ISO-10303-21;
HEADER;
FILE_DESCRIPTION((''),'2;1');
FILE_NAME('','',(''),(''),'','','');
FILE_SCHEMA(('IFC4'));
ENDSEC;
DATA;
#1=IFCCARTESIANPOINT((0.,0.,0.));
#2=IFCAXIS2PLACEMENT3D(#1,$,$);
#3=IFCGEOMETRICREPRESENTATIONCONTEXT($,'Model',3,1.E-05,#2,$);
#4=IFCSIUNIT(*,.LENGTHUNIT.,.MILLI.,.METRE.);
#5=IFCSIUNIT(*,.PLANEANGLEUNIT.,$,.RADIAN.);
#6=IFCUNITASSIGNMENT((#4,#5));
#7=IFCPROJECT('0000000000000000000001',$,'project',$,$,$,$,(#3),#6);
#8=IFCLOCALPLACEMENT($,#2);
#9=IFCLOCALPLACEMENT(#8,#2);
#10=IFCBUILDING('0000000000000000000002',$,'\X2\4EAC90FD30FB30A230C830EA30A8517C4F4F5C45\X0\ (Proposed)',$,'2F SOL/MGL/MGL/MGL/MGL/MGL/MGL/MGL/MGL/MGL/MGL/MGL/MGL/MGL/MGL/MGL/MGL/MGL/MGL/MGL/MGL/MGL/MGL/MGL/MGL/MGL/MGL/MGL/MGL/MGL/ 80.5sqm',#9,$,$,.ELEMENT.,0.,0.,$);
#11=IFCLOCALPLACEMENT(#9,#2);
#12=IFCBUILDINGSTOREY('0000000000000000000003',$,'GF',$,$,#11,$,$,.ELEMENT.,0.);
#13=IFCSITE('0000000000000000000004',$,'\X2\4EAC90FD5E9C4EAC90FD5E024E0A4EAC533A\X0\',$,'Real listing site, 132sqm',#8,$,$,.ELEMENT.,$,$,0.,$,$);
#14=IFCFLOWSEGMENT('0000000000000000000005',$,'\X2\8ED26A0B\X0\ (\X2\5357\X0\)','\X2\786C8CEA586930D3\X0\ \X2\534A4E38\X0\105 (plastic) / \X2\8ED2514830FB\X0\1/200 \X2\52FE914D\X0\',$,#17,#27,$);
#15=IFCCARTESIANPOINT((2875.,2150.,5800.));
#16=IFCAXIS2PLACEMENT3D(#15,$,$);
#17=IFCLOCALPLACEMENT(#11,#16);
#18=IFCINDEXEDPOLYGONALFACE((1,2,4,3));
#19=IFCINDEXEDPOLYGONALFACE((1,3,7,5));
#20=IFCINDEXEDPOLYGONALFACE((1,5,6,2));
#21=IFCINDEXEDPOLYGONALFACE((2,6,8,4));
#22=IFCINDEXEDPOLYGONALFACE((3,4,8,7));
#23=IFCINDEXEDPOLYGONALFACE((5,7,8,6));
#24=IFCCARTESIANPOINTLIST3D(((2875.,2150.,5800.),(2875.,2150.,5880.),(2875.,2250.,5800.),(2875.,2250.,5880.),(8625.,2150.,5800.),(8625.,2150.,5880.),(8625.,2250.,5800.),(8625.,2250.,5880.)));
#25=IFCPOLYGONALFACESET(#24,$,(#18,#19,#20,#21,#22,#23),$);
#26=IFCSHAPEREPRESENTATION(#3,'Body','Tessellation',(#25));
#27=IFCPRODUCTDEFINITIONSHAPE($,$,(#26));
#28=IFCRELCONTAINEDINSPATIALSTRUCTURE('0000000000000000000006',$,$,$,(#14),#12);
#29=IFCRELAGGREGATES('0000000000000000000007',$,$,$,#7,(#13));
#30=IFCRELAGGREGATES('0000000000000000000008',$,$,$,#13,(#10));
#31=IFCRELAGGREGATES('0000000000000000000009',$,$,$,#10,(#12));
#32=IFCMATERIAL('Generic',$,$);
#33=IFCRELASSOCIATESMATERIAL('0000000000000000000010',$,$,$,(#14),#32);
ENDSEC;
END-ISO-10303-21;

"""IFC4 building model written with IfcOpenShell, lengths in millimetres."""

from ifc_helpers import new_model, si_unit, frame, frame_2d, origin, place, context, project, spatial, rectangle, extrude, material, element, save


model = new_model("IFC4")

# Units and contexts
model_context = context("Model", 3, precision=1e-05, world=origin())
ifc_project = project(units=[si_unit("LENGTHUNIT", "METRE", prefix="MILLI"), si_unit("PLANEANGLEUNIT", "RADIAN")], contexts=[model_context])

# Site, building, storey
site_placement = place(None, origin())
site = spatial("IfcSite", under=ifc_project, at=site_placement, Name="京都府京都市上京区", ObjectType="Real listing site, 132sqm", CompositionType="ELEMENT", RefElevation=0.0)
building_placement = place(site_placement, origin())
building = spatial("IfcBuilding", under=site, at=building_placement, Name="京都・アトリエ兼住居 (Proposed)", ObjectType="2F SOL/MGL/MGL/MGL/MGL/MGL/MGL/MGL/MGL/MGL/MGL/MGL/MGL/MGL/MGL/MGL/MGL/MGL/MGL/MGL/MGL/MGL/MGL/MGL/MGL/MGL/MGL/MGL/MGL/MGL/ 80.5sqm", CompositionType="ELEMENT", ElevationOfRefHeight=0.0, ElevationOfTerrain=0.0)
storey_placement = place(building_placement, origin())
storey = spatial("IfcBuildingStorey", under=building, at=storey_placement, Name="GF", CompositionType="ELEMENT", Elevation=0.0)

# Flow segment
ifc_material_1 = material(Name="Generic")
flow_segment_placement = place(storey_placement, frame((2875.0, 2150.0, 5800.0)))
element("IfcFlowSegment", 1, at=flow_segment_placement, inside=storey, material=ifc_material_1, Name="軒樋 (南)", Description="硬質塩ビ 半丸105 (plastic) / 軒先・1/200 勾配", context=model_context, shape_type="SweptSolid", body=[
    extrude(rectangle(XDim=5750.0, YDim=100.0, at=frame_2d((2875.0, 50.0))), frame((2875.0, 2150.0, 5800.0)), (0.0, 0.0, 1.0), 80.0),
])

save(model, "model.ifc")
